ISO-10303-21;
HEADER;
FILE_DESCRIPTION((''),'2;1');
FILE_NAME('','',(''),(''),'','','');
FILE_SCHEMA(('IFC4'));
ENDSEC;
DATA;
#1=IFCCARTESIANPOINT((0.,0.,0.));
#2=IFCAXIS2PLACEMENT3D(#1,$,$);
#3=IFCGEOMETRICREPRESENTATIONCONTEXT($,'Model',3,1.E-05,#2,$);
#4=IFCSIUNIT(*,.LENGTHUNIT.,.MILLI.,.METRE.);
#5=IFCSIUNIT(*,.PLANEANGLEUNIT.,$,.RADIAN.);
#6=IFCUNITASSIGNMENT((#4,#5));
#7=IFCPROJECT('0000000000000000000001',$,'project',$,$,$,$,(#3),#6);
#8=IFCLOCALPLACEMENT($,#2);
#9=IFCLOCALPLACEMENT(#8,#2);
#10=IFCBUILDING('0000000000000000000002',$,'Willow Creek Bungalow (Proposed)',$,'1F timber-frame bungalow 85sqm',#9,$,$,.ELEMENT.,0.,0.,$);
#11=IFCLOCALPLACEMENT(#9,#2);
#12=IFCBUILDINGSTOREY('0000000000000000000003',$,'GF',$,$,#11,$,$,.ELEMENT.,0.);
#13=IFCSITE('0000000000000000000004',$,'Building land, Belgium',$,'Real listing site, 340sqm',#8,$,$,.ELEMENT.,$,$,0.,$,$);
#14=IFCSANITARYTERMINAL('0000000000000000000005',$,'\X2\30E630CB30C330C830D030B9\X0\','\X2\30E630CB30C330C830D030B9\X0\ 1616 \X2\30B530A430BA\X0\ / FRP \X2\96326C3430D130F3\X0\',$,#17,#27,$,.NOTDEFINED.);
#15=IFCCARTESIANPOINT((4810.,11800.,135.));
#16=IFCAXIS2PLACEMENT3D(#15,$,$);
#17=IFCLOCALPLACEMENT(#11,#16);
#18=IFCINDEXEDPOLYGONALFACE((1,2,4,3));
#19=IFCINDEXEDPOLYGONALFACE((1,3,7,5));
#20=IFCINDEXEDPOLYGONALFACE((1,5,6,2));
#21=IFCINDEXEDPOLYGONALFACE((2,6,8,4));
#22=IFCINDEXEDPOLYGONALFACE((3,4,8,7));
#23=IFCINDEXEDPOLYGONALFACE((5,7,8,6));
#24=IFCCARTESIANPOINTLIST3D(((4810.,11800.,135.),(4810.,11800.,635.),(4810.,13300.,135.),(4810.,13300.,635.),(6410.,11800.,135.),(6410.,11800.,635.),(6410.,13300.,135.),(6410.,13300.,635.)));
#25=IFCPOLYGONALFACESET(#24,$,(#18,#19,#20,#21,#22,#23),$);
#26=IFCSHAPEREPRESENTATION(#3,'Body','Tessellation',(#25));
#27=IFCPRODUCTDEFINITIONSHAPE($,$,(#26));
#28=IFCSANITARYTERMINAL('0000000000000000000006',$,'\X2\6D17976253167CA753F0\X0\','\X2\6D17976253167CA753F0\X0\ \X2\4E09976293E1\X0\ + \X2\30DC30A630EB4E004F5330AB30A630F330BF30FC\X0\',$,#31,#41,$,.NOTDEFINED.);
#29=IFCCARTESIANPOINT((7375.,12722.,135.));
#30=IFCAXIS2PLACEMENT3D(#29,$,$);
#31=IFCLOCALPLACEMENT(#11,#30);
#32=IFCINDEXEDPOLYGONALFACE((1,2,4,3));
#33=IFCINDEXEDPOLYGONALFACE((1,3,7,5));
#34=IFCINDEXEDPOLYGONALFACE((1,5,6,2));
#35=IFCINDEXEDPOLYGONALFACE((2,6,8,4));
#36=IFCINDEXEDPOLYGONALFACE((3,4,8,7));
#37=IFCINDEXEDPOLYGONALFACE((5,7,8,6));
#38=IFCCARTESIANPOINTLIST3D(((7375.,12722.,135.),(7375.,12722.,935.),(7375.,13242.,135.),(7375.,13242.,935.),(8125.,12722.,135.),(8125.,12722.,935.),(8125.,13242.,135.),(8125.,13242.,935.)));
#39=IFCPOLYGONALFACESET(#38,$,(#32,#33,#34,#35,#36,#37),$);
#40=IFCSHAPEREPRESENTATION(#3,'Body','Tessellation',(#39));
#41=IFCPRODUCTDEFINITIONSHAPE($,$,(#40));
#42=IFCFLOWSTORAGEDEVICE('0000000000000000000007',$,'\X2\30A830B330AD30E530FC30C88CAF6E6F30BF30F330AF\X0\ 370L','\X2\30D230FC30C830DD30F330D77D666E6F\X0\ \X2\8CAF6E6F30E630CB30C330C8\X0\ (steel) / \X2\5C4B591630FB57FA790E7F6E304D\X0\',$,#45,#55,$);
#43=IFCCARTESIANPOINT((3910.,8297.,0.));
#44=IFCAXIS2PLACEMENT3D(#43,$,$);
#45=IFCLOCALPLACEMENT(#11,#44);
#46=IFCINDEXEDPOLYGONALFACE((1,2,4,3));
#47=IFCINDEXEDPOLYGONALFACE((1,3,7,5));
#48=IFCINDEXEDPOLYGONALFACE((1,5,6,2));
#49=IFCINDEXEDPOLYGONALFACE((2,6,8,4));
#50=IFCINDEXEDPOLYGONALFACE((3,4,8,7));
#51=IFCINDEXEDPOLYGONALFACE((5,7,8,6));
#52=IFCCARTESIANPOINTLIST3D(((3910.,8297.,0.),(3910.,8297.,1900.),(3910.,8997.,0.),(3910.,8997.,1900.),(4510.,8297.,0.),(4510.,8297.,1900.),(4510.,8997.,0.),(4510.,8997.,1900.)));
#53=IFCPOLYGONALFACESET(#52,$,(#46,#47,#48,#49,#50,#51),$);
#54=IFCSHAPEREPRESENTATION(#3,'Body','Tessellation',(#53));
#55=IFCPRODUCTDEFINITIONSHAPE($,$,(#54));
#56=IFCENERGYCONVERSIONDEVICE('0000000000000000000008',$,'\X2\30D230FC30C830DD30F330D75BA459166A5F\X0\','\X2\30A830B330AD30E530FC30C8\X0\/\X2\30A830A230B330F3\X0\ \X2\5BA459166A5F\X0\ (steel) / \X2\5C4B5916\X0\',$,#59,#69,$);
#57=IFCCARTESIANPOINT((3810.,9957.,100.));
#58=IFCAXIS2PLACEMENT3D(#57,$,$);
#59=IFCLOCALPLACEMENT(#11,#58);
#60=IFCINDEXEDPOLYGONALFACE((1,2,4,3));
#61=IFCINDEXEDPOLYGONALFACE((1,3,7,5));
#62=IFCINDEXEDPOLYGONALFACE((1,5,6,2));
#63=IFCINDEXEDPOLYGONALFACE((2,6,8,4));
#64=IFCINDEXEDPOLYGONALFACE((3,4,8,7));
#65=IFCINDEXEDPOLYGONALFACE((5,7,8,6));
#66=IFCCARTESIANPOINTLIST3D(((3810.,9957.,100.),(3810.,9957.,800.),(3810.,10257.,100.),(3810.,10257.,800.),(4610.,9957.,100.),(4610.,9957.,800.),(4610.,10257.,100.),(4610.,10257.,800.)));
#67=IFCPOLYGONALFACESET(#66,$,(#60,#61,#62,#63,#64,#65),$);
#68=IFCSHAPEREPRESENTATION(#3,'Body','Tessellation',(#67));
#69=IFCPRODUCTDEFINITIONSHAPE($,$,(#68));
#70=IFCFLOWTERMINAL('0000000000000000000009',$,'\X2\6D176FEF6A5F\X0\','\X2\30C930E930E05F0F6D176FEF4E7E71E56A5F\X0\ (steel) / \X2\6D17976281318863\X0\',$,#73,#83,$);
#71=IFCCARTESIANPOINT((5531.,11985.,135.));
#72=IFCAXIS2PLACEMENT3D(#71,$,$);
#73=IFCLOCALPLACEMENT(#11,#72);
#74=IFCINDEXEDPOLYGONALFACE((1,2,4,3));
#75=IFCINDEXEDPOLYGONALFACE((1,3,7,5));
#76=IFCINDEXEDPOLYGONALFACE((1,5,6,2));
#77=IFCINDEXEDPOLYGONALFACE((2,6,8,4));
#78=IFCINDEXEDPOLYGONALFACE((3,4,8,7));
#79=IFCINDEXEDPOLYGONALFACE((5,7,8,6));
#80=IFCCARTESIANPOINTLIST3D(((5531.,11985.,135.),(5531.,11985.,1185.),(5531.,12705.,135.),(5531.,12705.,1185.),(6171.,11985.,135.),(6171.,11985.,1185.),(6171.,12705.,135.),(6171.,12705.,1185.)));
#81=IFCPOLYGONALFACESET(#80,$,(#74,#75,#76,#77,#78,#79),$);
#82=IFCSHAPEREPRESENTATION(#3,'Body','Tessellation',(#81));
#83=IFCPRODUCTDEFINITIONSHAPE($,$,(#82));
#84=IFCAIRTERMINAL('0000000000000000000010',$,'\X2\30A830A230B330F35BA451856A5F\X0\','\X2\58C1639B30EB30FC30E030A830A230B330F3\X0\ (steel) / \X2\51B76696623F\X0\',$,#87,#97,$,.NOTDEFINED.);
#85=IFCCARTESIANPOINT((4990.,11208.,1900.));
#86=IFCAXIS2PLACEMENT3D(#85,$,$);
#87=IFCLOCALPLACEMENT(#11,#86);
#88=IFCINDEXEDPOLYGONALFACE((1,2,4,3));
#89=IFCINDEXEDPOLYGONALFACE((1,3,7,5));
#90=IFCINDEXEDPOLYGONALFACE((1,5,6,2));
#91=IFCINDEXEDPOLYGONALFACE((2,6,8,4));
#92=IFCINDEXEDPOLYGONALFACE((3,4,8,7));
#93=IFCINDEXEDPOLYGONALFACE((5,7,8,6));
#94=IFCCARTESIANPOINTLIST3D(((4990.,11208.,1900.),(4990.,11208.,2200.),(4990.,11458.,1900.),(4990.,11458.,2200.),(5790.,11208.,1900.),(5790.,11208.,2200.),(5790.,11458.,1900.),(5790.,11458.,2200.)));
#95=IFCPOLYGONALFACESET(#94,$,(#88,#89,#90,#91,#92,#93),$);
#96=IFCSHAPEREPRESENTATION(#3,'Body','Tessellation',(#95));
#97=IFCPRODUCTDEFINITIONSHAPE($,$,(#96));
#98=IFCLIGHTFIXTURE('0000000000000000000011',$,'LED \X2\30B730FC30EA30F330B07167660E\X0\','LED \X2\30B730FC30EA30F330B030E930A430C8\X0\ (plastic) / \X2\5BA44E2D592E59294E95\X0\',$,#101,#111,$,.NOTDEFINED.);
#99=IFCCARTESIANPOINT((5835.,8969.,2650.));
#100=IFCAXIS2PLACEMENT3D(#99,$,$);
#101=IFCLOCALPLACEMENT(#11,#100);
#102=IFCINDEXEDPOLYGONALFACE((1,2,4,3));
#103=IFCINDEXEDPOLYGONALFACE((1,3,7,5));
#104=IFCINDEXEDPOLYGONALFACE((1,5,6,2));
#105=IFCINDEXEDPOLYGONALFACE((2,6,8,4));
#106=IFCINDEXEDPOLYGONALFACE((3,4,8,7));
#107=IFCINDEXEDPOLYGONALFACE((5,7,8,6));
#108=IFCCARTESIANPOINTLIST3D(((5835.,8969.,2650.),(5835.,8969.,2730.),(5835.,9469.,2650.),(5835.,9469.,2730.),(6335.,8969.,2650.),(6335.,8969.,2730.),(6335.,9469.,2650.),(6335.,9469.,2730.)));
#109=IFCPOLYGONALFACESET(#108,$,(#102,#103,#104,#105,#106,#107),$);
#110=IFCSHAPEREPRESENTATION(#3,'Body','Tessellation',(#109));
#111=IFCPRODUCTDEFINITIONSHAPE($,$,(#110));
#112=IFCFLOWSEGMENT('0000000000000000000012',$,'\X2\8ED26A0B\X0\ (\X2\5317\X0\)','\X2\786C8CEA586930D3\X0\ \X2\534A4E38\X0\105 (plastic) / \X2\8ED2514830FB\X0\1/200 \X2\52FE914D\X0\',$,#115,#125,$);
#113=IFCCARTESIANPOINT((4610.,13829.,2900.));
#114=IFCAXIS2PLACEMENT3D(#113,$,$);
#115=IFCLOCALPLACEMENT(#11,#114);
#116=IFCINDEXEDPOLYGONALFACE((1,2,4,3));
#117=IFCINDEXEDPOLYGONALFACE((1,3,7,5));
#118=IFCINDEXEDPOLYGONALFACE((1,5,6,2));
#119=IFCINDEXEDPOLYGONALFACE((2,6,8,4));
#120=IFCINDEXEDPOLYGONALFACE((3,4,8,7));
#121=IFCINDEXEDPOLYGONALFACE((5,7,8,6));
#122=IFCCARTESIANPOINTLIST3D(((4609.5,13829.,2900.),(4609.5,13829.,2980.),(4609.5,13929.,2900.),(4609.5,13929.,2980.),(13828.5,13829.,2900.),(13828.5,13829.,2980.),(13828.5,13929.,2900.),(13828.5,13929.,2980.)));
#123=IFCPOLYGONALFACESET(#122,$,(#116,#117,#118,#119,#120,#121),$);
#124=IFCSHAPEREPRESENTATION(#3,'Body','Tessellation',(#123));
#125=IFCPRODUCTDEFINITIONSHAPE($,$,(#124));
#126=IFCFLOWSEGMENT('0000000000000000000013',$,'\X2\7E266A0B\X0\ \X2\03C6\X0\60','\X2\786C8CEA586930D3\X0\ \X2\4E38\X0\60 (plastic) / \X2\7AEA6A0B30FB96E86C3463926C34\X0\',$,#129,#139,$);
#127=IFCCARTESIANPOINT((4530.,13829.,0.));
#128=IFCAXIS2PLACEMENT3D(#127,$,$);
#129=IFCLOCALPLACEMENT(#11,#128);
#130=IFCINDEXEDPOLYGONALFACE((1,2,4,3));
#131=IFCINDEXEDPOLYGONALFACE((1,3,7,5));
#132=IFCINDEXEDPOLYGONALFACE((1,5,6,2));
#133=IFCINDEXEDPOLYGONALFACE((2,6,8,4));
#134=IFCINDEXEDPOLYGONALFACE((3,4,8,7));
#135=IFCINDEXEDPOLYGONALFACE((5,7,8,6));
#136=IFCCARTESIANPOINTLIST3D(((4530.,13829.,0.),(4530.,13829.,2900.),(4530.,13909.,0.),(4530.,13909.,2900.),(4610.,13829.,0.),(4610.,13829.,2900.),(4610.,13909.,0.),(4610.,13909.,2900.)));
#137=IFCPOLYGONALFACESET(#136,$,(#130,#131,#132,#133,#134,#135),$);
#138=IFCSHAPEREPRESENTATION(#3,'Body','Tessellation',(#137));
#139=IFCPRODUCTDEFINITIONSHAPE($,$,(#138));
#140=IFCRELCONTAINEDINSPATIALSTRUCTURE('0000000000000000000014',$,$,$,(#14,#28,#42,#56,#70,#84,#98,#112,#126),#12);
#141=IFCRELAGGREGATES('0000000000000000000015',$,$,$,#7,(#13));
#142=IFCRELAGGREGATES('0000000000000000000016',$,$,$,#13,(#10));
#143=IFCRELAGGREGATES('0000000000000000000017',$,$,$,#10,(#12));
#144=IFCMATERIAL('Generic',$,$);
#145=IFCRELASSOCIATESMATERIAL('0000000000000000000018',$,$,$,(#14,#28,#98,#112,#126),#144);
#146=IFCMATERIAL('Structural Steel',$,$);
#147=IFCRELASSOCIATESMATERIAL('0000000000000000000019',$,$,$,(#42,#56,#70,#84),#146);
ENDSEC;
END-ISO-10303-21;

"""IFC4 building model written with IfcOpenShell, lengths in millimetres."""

from ifc_helpers import new_model, si_unit, frame, frame_2d, origin, place, context, project, spatial, rectangle, extrude, material, element, save


model = new_model("IFC4")

# Units and contexts
model_context = context("Model", 3, precision=1e-05, world=origin())
ifc_project = project(units=[si_unit("LENGTHUNIT", "METRE", prefix="MILLI"), si_unit("PLANEANGLEUNIT", "RADIAN")], contexts=[model_context])

# Site, building, storey
site_placement = place(None, origin())
site = spatial("IfcSite", under=ifc_project, at=site_placement, Name="Building land, Belgium", ObjectType="Real listing site, 340sqm", CompositionType="ELEMENT", RefElevation=0.0)
building_placement = place(site_placement, origin())
building = spatial("IfcBuilding", under=site, at=building_placement, Name="Willow Creek Bungalow (Proposed)", ObjectType="1F timber-frame bungalow 85sqm", CompositionType="ELEMENT", ElevationOfRefHeight=0.0, ElevationOfTerrain=0.0)
storey_placement = place(building_placement, origin())
storey = spatial("IfcBuildingStorey", under=building, at=storey_placement, Name="GF", CompositionType="ELEMENT", Elevation=0.0)

# Shared definitions
ifc_material_1 = material(Name="Structural Steel")

# Shared definitions
ifc_material_2 = material(Name="Generic")

# Sanitary terminals
sanitary_terminal_1_placement = place(storey_placement, frame((4810.0, 11800.0, 135.0)))
element("IfcSanitaryTerminal", 1, at=sanitary_terminal_1_placement, inside=storey, material=ifc_material_2, Name="ユニットバス", Description="ユニットバス 1616 サイズ / FRP 防水パン", PredefinedType="NOTDEFINED", context=model_context, shape_type="SweptSolid", body=[
    extrude(rectangle(XDim=1600.0, YDim=1500.0, at=frame_2d((800.0, 750.0))), frame((4810.0, 11800.0, 135.0)), (0.0, 0.0, 1.0), 500.0),
])
sanitary_terminal_2_placement = place(storey_placement, frame((7375.0, 12722.0, 135.0)))
element("IfcSanitaryTerminal", 2, at=sanitary_terminal_2_placement, inside=storey, material=ifc_material_2, Name="洗面化粧台", Description="洗面化粧台 三面鏡 + ボウル一体カウンター", PredefinedType="NOTDEFINED", context=model_context, shape_type="SweptSolid", body=[
    extrude(rectangle(XDim=750.0, YDim=520.0, at=frame_2d((375.0, 260.0))), frame((7375.0, 12722.0, 135.0)), (0.0, 0.0, 1.0), 800.0),
])

# Flow storage device
flow_storage_device_placement = place(storey_placement, frame((3910.0, 8297.0, 0.0)))
element("IfcFlowStorageDevice", 3, at=flow_storage_device_placement, inside=storey, material=ifc_material_1, Name="エコキュート貯湯タンク 370L", Description="ヒートポンプ給湯 貯湯ユニット (steel) / 屋外・基礎置き", context=model_context, shape_type="SweptSolid", body=[
    extrude(rectangle(XDim=600.0, YDim=700.0, at=frame_2d((300.0, 350.0))), frame((3910.0, 8297.0, 0.0)), (0.0, 0.0, 1.0), 1900.0),
])

# Energy conversion device
energy_conversion_device_placement = place(storey_placement, frame((3810.0, 9957.0, 100.0)))
element("IfcEnergyConversionDevice", 4, at=energy_conversion_device_placement, inside=storey, material=ifc_material_1, Name="ヒートポンプ室外機", Description="エコキュート/エアコン 室外機 (steel) / 屋外", context=model_context, shape_type="SweptSolid", body=[
    extrude(rectangle(XDim=800.0, YDim=300.0, at=frame_2d((400.0, 150.0))), frame((3810.0, 9957.0, 100.0)), (0.0, 0.0, 1.0), 700.0),
])

# Flow terminal
flow_terminal_placement = place(storey_placement, frame((5531.0, 11985.0, 135.0)))
element("IfcFlowTerminal", 5, at=flow_terminal_placement, inside=storey, material=ifc_material_1, Name="洗濯機", Description="ドラム式洗濯乾燥機 (steel) / 洗面脱衣", context=model_context, shape_type="SweptSolid", body=[
    extrude(rectangle(XDim=640.0, YDim=720.0, at=frame_2d((320.0, 360.0))), frame((5531.0, 11985.0, 135.0)), (0.0, 0.0, 1.0), 1050.0),
])

# Air terminal
air_terminal_placement = place(storey_placement, frame((4990.0, 11208.0, 1900.0)))
element("IfcAirTerminal", 6, at=air_terminal_placement, inside=storey, material=ifc_material_1, Name="エアコン室内機", Description="壁掛ルームエアコン (steel) / 冷暖房", PredefinedType="NOTDEFINED", context=model_context, shape_type="SweptSolid", body=[
    extrude(rectangle(XDim=800.0, YDim=250.0, at=frame_2d((400.0, 125.0))), frame((4990.0, 11208.0, 1900.0)), (0.0, 0.0, 1.0), 300.0),
])

# Light fixture
light_fixture_placement = place(storey_placement, frame((5835.0, 8969.0, 2650.0)))
element("IfcLightFixture", 7, at=light_fixture_placement, inside=storey, material=ifc_material_2, Name="LED シーリング照明", Description="LED シーリングライト (plastic) / 室中央天井", PredefinedType="NOTDEFINED", context=model_context, shape_type="SweptSolid", body=[
    extrude(rectangle(XDim=500.0, YDim=500.0, at=frame_2d((250.0, 250.0))), frame((5835.0, 8969.0, 2650.0)), (0.0, 0.0, 1.0), 80.0),
])

# Flow segments
flow_segment_1_placement = place(storey_placement, frame((4610.0, 13829.0, 2900.0)))
element("IfcFlowSegment", 8, at=flow_segment_1_placement, inside=storey, material=ifc_material_2, Name="軒樋 (北)", Description="硬質塩ビ 半丸105 (plastic) / 軒先・1/200 勾配", context=model_context, shape_type="SweptSolid", body=[
    extrude(rectangle(XDim=9219.0, YDim=100.0, at=frame_2d((4609.0, 50.0))), frame((4610.0, 13829.0, 2900.0)), (0.0, 0.0, 1.0), 80.0),
])
flow_segment_2_placement = place(storey_placement, frame((4530.0, 13829.0, 0.0)))
element("IfcFlowSegment", 9, at=flow_segment_2_placement, inside=storey, material=ifc_material_2, Name="縦樋 φ60", Description="硬質塩ビ 丸60 (plastic) / 竪樋・雨水排水", context=model_context, shape_type="SweptSolid", body=[
    extrude(rectangle(XDim=80.0, YDim=80.0, at=frame_2d((40.0, 40.0))), frame((4530.0, 13829.0, 0.0)), (0.0, 0.0, 1.0), 2900.0),
])

save(model, "model.ifc")
